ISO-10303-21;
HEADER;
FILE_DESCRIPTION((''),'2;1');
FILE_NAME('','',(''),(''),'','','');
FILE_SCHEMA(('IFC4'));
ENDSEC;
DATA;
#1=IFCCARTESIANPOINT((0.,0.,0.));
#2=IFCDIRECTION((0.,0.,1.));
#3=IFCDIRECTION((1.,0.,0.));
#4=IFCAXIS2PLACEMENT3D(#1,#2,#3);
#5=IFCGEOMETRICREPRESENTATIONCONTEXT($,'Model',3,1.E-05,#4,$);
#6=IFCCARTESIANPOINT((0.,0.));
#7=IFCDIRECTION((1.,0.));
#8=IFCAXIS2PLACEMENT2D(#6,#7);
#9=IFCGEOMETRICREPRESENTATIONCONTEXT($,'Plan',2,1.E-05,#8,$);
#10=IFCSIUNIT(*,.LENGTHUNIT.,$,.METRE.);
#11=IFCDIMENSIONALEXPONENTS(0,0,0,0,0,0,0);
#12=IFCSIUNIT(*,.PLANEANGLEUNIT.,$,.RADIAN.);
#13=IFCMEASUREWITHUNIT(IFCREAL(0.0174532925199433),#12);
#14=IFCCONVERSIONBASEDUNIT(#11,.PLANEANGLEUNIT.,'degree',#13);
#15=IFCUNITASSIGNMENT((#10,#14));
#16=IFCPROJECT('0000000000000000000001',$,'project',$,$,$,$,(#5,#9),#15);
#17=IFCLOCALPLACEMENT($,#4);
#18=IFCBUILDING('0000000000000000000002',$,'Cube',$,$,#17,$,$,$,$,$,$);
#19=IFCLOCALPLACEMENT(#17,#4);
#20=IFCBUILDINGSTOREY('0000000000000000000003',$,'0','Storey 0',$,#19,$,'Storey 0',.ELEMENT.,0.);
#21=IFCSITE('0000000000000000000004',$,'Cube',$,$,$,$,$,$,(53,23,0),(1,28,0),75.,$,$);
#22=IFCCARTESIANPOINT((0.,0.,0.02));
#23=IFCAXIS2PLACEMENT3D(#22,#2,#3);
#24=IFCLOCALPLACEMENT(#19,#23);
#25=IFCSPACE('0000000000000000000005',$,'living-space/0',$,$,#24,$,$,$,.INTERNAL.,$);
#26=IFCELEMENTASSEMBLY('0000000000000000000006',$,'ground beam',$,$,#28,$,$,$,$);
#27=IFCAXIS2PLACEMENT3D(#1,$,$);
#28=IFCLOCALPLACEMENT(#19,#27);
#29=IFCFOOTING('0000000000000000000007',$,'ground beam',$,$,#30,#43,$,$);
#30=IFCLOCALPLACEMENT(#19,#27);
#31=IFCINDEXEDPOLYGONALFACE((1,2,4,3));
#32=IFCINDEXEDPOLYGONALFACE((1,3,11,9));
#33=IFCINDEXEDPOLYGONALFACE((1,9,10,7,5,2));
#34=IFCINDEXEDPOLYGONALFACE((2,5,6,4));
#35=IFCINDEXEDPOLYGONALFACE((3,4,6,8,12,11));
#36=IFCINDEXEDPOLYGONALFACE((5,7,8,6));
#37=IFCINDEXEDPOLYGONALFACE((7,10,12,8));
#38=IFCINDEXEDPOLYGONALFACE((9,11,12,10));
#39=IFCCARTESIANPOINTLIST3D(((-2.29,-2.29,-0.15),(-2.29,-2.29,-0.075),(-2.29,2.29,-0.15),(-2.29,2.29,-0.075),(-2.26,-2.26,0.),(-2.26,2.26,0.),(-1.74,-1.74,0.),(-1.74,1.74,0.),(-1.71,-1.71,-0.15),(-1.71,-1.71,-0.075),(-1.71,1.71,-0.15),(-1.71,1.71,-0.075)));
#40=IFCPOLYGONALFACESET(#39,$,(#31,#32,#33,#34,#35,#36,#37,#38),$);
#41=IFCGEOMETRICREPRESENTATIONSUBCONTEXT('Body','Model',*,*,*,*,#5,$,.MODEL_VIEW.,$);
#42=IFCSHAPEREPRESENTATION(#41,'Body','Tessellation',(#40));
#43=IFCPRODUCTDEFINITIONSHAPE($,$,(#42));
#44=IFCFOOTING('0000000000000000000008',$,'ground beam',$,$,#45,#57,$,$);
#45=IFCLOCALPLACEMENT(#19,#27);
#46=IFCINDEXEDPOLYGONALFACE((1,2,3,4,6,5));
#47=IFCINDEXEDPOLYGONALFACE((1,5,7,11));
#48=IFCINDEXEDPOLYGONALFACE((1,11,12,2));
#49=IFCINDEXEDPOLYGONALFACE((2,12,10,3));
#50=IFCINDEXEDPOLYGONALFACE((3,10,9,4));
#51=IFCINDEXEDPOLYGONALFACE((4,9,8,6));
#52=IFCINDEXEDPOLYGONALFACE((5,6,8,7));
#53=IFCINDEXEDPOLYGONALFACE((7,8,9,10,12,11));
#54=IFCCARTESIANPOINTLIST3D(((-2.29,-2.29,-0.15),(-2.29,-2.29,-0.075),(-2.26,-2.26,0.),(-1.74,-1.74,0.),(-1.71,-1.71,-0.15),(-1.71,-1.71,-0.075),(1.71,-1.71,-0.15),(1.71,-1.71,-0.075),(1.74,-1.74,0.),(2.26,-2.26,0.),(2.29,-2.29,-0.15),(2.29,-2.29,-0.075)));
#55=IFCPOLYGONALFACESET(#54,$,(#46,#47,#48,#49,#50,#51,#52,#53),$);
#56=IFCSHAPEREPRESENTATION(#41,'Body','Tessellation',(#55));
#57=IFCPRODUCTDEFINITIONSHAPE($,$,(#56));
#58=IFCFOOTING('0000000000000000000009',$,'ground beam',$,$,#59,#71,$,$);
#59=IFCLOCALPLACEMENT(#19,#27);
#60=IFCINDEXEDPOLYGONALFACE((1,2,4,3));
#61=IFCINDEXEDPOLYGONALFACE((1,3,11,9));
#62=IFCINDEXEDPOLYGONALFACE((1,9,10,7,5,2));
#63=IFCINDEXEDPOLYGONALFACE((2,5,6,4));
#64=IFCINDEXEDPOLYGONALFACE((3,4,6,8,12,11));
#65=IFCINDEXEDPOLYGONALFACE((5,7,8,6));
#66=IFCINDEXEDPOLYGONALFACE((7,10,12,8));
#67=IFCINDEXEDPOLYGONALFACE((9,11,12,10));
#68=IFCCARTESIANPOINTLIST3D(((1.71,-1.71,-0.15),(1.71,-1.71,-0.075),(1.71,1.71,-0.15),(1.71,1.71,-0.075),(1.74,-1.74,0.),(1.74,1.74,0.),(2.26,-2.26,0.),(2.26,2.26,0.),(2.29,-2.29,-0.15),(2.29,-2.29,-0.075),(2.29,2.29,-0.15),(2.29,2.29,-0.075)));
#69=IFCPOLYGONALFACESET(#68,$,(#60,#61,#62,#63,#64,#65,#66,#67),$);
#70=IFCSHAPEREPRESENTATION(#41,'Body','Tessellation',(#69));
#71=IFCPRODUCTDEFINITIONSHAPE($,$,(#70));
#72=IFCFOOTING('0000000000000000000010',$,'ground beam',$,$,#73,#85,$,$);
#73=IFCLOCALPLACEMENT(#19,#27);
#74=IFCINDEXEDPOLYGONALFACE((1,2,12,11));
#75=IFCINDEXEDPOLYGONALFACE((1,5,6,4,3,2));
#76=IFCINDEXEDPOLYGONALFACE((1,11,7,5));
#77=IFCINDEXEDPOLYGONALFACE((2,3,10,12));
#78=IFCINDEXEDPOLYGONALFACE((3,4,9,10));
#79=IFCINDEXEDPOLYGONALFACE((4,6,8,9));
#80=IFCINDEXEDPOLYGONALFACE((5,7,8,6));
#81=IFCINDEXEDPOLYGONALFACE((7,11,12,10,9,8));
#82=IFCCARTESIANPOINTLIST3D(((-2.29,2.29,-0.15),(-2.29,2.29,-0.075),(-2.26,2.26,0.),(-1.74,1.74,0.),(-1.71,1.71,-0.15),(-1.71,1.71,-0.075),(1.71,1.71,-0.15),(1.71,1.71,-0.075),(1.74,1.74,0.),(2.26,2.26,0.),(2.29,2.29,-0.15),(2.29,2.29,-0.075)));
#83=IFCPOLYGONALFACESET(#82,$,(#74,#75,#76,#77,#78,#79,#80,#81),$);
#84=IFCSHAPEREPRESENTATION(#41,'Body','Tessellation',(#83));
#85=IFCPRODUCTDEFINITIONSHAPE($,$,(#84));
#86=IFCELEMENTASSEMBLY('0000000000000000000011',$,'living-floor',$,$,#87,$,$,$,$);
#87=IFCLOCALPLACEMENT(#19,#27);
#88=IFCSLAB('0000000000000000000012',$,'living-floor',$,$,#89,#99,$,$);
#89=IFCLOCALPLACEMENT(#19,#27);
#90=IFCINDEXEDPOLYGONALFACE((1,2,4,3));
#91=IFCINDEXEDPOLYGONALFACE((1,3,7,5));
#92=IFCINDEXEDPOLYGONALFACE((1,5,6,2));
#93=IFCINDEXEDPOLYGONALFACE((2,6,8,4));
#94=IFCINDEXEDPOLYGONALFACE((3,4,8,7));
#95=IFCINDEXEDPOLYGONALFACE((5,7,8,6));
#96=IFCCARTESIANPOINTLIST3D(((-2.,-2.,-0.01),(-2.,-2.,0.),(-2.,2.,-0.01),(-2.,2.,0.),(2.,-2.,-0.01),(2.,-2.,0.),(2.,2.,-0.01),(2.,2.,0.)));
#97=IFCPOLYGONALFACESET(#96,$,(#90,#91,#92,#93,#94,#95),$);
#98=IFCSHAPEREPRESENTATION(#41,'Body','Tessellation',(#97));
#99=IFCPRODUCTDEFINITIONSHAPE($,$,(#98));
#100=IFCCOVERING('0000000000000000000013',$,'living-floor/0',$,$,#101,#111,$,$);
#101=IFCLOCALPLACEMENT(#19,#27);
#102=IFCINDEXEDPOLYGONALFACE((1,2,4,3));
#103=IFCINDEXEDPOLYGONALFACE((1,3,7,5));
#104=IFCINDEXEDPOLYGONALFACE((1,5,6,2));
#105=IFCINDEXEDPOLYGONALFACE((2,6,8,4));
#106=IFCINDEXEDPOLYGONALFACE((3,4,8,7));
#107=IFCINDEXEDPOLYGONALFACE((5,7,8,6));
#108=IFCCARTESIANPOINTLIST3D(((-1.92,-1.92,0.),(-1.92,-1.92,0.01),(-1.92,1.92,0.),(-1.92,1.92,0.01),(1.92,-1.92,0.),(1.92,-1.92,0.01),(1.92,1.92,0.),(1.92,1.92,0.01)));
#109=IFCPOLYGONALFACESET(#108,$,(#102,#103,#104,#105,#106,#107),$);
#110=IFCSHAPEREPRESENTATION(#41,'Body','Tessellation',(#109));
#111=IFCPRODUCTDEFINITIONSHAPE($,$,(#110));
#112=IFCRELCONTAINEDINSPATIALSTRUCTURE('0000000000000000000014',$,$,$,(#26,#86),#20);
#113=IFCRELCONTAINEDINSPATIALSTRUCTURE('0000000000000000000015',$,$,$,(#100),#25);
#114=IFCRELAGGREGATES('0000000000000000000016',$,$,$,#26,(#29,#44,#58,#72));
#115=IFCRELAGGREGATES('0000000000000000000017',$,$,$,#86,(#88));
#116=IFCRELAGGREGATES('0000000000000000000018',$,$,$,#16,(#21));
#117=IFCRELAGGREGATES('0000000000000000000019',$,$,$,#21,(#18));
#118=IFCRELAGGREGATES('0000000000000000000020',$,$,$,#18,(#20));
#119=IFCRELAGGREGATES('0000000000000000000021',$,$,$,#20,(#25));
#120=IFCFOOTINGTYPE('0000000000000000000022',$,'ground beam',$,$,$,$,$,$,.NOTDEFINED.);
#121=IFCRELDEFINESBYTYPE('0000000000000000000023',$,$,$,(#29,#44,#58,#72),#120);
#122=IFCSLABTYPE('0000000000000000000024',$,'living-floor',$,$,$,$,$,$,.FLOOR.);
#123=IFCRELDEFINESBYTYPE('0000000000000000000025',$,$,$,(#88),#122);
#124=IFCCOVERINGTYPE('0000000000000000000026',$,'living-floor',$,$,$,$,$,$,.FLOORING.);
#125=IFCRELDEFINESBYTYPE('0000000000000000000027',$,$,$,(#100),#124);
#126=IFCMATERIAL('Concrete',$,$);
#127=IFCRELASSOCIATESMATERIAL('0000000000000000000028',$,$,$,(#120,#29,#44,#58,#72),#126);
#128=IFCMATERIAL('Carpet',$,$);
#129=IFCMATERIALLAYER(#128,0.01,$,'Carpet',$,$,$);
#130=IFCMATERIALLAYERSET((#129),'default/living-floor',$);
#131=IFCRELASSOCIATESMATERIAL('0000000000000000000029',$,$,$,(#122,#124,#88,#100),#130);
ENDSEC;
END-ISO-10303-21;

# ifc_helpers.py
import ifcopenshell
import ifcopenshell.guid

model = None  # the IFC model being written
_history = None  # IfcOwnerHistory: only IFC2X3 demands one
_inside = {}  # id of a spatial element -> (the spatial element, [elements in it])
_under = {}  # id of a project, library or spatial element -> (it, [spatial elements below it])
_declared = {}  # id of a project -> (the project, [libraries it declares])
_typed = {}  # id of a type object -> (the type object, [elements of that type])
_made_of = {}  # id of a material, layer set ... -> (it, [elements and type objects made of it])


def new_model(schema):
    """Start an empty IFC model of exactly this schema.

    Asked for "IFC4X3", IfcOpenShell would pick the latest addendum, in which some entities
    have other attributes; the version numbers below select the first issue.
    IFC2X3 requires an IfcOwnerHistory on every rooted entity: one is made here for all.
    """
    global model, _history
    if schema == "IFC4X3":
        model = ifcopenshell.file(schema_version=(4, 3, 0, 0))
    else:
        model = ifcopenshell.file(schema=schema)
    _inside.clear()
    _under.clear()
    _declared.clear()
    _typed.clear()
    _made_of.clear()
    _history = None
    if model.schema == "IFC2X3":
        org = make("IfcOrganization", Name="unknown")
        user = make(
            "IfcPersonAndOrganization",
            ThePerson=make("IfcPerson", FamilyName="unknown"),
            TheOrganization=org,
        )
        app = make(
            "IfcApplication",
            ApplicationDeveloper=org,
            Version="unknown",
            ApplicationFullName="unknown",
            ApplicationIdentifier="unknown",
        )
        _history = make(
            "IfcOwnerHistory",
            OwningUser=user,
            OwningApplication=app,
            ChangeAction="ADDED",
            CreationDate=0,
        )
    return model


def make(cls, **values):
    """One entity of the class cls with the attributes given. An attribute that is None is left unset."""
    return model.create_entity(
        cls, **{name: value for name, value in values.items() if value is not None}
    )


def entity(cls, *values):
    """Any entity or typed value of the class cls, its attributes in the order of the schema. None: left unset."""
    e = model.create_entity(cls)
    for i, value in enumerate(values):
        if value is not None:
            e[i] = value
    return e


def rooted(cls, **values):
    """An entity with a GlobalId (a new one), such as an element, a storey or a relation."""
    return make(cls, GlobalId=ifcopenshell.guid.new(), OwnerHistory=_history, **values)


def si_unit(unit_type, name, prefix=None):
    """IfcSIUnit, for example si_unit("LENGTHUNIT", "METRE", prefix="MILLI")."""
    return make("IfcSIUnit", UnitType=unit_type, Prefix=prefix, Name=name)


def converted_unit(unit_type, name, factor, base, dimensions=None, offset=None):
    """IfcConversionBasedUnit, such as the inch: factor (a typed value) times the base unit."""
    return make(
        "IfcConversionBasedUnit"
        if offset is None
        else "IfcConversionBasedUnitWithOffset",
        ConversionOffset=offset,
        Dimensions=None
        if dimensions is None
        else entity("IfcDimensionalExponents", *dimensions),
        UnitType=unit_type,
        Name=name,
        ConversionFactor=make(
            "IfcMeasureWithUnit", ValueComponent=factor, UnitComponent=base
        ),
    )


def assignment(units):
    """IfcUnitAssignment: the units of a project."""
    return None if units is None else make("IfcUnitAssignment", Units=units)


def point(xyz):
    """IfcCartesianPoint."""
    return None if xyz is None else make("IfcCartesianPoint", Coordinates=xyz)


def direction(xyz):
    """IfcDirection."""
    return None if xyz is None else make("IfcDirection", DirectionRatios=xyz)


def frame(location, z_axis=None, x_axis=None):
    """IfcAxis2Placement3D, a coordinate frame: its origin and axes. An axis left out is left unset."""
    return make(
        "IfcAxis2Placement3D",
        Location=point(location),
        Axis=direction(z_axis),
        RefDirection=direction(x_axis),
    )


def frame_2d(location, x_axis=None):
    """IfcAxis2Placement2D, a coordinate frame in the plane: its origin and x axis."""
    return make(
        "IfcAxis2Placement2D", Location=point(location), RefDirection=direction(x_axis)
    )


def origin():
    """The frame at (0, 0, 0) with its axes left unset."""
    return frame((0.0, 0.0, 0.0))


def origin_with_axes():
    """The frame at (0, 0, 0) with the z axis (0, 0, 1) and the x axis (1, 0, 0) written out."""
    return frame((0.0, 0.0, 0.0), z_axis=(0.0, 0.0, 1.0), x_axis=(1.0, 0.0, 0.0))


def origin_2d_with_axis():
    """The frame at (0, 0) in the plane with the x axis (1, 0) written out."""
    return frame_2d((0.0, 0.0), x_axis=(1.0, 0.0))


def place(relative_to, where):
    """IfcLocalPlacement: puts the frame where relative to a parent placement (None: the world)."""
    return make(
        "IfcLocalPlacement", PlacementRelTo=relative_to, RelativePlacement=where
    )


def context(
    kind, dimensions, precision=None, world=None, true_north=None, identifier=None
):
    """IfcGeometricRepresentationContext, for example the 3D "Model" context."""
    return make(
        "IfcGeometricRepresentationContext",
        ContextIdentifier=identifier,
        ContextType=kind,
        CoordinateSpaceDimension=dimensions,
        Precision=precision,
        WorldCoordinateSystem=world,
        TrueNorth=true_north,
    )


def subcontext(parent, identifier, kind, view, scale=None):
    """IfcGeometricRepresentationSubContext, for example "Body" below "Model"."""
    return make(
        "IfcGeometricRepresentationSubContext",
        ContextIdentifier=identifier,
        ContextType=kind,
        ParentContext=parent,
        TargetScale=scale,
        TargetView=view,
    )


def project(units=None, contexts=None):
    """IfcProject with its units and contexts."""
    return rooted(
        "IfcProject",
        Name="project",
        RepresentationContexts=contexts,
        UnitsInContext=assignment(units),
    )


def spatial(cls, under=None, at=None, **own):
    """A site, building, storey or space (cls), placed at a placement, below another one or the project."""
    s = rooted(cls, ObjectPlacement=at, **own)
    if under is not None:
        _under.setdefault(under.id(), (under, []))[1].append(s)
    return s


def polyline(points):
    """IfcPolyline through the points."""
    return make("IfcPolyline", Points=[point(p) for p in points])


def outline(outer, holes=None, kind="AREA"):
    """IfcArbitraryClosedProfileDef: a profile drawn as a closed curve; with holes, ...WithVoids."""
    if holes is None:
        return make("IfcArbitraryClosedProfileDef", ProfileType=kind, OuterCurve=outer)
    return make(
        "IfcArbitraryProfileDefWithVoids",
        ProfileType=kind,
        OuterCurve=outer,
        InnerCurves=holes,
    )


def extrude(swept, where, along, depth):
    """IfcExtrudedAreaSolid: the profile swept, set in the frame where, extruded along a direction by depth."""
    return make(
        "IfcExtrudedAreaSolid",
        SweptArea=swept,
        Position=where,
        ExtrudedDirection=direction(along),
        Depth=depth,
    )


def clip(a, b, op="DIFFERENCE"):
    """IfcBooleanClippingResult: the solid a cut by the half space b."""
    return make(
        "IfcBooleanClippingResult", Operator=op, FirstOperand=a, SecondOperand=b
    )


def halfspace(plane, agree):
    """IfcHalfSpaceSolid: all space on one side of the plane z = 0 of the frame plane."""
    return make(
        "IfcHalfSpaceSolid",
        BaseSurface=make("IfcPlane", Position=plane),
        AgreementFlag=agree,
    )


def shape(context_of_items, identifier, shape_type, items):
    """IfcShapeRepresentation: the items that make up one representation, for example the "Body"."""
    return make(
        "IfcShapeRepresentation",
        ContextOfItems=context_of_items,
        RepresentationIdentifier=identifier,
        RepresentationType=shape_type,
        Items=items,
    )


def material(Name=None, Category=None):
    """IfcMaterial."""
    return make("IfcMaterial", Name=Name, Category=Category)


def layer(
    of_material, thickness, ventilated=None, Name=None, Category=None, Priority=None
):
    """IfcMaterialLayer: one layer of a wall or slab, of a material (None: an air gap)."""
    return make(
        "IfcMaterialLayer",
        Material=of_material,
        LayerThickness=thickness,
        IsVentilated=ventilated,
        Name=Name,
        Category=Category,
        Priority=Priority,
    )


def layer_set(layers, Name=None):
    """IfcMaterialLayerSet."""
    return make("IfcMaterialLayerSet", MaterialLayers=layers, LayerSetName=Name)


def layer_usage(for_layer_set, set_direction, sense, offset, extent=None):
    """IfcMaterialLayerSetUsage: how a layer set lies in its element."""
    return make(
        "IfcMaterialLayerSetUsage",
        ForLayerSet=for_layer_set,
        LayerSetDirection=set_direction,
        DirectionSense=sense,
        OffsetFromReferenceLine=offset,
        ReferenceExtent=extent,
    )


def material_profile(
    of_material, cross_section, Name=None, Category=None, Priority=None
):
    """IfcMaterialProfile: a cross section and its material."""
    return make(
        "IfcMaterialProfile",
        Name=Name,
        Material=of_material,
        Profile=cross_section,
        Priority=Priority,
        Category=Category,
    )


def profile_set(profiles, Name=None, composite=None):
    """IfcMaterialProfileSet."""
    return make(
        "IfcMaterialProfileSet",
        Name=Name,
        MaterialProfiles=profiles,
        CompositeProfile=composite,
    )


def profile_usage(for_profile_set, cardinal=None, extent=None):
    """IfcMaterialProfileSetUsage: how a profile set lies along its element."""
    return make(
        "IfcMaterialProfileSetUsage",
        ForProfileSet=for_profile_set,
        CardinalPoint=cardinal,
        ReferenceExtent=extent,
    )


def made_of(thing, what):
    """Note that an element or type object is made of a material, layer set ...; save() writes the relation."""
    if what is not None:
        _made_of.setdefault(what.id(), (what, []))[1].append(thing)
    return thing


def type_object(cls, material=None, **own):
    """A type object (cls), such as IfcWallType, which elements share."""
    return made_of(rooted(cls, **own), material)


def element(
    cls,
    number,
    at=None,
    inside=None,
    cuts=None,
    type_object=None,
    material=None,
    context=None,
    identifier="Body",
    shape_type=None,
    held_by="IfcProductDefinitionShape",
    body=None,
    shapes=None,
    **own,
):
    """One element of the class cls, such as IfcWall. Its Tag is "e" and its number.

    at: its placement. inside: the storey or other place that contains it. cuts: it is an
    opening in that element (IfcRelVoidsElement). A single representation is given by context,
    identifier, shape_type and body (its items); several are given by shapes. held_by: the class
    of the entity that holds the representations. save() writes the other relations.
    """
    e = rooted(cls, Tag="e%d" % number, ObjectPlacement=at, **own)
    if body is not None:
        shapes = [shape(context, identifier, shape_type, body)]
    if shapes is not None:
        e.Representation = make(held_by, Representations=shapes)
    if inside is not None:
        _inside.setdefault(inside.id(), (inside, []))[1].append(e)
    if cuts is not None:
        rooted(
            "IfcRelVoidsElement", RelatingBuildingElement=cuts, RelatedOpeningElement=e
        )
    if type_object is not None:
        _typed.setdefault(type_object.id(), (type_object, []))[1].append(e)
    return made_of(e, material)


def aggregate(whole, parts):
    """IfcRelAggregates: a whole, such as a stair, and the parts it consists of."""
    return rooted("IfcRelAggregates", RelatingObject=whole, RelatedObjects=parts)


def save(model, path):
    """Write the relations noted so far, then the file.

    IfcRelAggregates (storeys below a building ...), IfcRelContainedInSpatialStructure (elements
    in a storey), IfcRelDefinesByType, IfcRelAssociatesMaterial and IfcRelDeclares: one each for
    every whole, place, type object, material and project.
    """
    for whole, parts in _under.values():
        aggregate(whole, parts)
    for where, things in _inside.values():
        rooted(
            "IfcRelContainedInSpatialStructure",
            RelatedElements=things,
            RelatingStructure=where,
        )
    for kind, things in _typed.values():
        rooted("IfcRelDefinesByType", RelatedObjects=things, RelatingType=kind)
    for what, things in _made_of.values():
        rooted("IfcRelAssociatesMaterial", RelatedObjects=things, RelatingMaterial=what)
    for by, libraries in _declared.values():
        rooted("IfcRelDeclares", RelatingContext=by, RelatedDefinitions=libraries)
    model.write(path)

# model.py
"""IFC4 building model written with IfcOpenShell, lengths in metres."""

from ifc_helpers import new_model, entity, si_unit, converted_unit, frame, origin, origin_with_axes, origin_2d_with_axis, place, context, subcontext, project, spatial, polyline, outline, extrude, clip, halfspace, material, layer, layer_set, layer_usage, material_profile, profile_set, profile_usage, type_object, element, aggregate, save


model = new_model("IFC4")

# Units and contexts
model_context = context("Model", 3, precision=1e-05, world=origin_with_axes())
plan_context = context("Plan", 2, precision=1e-05, world=origin_2d_with_axis())
body_context = subcontext(model_context, "Body", "Model", "MODEL_VIEW")
ifc_project = project(units=[si_unit("LENGTHUNIT", "METRE"), converted_unit("PLANEANGLEUNIT", "degree", entity("IfcReal", 0.0174532925199433), si_unit("PLANEANGLEUNIT", "RADIAN"), dimensions=[0, 0, 0, 0, 0, 0, 0])], contexts=[model_context, plan_context])

# Site, building, storey
site = spatial("IfcSite", under=ifc_project, Name="Cube", RefLatitude=(53, 23, 0), RefLongitude=(1, 28, 0), RefElevation=75.0)
building_placement = place(None, origin_with_axes())
building = spatial("IfcBuilding", under=site, at=building_placement, Name="Cube")
storey_placement = place(building_placement, origin_with_axes())
storey = spatial("IfcBuildingStorey", under=building, at=storey_placement, Name="0", Description="Storey 0", LongName="Storey 0", CompositionType="ELEMENT", Elevation=0.0)

# Element assembly, footings
assembly_1_placement = place(storey_placement, origin_with_axes())
assembly_1 = element("IfcElementAssembly", 1, at=assembly_1_placement, inside=storey, Name="ground beam")
ifc_material_1 = material(Name="Concrete")
ifc_material_profile = material_profile(ifc_material_1, outline(polyline([(-0.26, 0.0), (-0.29, -0.075), (-0.29, -0.15), (0.29, -0.15), (0.29, -0.075), (0.26, 0.0), (-0.26, 0.0)])))
ifc_profile_set = profile_set([ifc_material_profile])
ifc_profile_usage_1 = profile_usage(ifc_profile_set)
footing_type = type_object("IfcFootingType", Name="ground beam", PredefinedType="NOTDEFINED", material=ifc_profile_set)
footing_1_placement = place(assembly_1_placement, frame((-2.0, -3.0, 0.0), z_axis=(0.0, 1.0, 0.0), x_axis=(-1.0, 0.0, 0.0)))
footing_1 = element("IfcFooting", 2, at=footing_1_placement, type_object=footing_type, material=ifc_profile_usage_1, Name="ground beam", context=body_context, shape_type="Clipping", body=[
    clip(clip(extrude(outline(polyline([(-0.26, 0.0), (-0.29, -0.075), (-0.29, -0.15), (0.29, -0.15), (0.29, -0.075), (0.26, 0.0), (-0.26, 0.0)])), origin_with_axes(), (0.0, 0.0, 1.0), 6.0), halfspace(frame((0.0, 0.0, 1.0), z_axis=(-0.707107, 0.0, -0.707107), x_axis=(0.0, 1.0, 0.0)), False)), halfspace(frame((0.0, 0.0, 5.0), z_axis=(-0.707107, 0.0, 0.707107), x_axis=(0.0, 1.0, 0.0)), False)),
])
ifc_profile_usage_2 = profile_usage(ifc_profile_set)
footing_2_placement = place(assembly_1_placement, frame((3.0, -2.0, 0.0), z_axis=(-1.0, 0.0, 0.0), x_axis=(0.0, -1.0, 0.0)))
footing_2 = element("IfcFooting", 3, at=footing_2_placement, type_object=footing_type, material=ifc_profile_usage_2, Name="ground beam", context=body_context, shape_type="Clipping", body=[
    clip(clip(extrude(outline(polyline([(-0.26, 0.0), (-0.29, -0.075), (-0.29, -0.15), (0.29, -0.15), (0.29, -0.075), (0.26, 0.0), (-0.26, 0.0)])), origin_with_axes(), (0.0, 0.0, 1.0), 6.0), halfspace(frame((0.0, 0.0, 1.0), z_axis=(-0.707107, 0.0, -0.707107), x_axis=(0.0, 1.0, 0.0)), False)), halfspace(frame((0.0, 0.0, 5.0), z_axis=(-0.707107, 0.0, 0.707107), x_axis=(0.0, 1.0, 0.0)), False)),
])
ifc_profile_usage_3 = profile_usage(ifc_profile_set)
footing_3_placement = place(assembly_1_placement, frame((2.0, 3.0, 0.0), z_axis=(0.0, -1.0, 0.0), x_axis=(1.0, 0.0, 0.0)))
footing_3 = element("IfcFooting", 4, at=footing_3_placement, type_object=footing_type, material=ifc_profile_usage_3, Name="ground beam", context=body_context, shape_type="Clipping", body=[
    clip(clip(extrude(outline(polyline([(-0.26, 0.0), (-0.29, -0.075), (-0.29, -0.15), (0.29, -0.15), (0.29, -0.075), (0.26, 0.0), (-0.26, 0.0)])), origin_with_axes(), (0.0, 0.0, 1.0), 6.0), halfspace(frame((0.0, 0.0, 1.0), z_axis=(-0.707107, 0.0, -0.707107), x_axis=(0.0, 1.0, 0.0)), False)), halfspace(frame((0.0, 0.0, 5.0), z_axis=(-0.707107, 0.0, 0.707107), x_axis=(0.0, 1.0, 0.0)), False)),
])
ifc_profile_usage_4 = profile_usage(ifc_profile_set)
footing_4_placement = place(assembly_1_placement, frame((-3.0, 2.0, 0.0), z_axis=(1.0, 0.0, 0.0), x_axis=(0.0, 1.0, 0.0)))
footing_4 = element("IfcFooting", 5, at=footing_4_placement, type_object=footing_type, material=ifc_profile_usage_4, Name="ground beam", context=body_context, shape_type="Clipping", body=[
    clip(clip(extrude(outline(polyline([(-0.26, 0.0), (-0.29, -0.075), (-0.29, -0.15), (0.29, -0.15), (0.29, -0.075), (0.26, 0.0), (-0.26, 0.0)])), origin_with_axes(), (0.0, 0.0, 1.0), 6.0), halfspace(frame((0.0, 0.0, 1.0), z_axis=(-0.707107, 0.0, -0.707107), x_axis=(0.0, 1.0, 0.0)), False)), halfspace(frame((0.0, 0.0, 5.0), z_axis=(-0.707107, 0.0, 0.707107), x_axis=(0.0, 1.0, 0.0)), False)),
])
aggregate(assembly_1, [footing_1, footing_2, footing_3, footing_4])

# Element assembly, slab
assembly_2_placement = place(storey_placement, origin_with_axes())
assembly_2 = element("IfcElementAssembly", 6, at=assembly_2_placement, inside=storey, Name="living-floor")
ifc_material_2 = material(Name="Carpet")
ifc_layer_1 = layer(ifc_material_2, 0.01, Name="Carpet")
ifc_layer_set_1 = layer_set([ifc_layer_1], Name="default/living-floor")
ifc_layer_usage_1 = layer_usage(ifc_layer_set_1, "AXIS3", "POSITIVE", 0.0)
slab_type = type_object("IfcSlabType", Name="living-floor", PredefinedType="FLOOR", material=ifc_layer_set_1)
slab_placement = place(assembly_2_placement, frame((2.0, 2.0, -0.01), z_axis=(0.0, 0.0, -1.0), x_axis=(0.0, 1.0, 0.0)))
slab = element("IfcSlab", 7, at=slab_placement, type_object=slab_type, material=ifc_layer_usage_1, Name="living-floor", context=body_context, shape_type="SweptSolid", body=[
    extrude(outline(polyline([(0.0, 0.0), (-4.0, 0.0), (-4.0, -4.0), (0.0, -4.0), (0.0, 0.0)])), origin(), (0.0, 0.0, -1.0), 0.01),
])
aggregate(assembly_2, [slab])

# Shared definitions
space_placement = place(storey_placement, frame((0.0, 0.0, 0.02), z_axis=(0.0, 0.0, 1.0), x_axis=(1.0, 0.0, 0.0)))
space = spatial("IfcSpace", under=storey, at=space_placement, Name="living-space/0", PredefinedType="INTERNAL")

# Covering
ifc_layer_usage_2 = layer_usage(ifc_layer_set_1, "AXIS3", "POSITIVE", 0.0)
covering_type = type_object("IfcCoveringType", Name="living-floor", PredefinedType="FLOORING", material=ifc_layer_set_1)
covering_placement = place(space_placement, frame((0.0, 0.0, -0.02), z_axis=(0.0, 0.0, 1.0), x_axis=(1.0, 0.0, 0.0)))
element("IfcCovering", 8, at=covering_placement, inside=space, type_object=covering_type, material=ifc_layer_usage_2, Name="living-floor/0", context=body_context, shape_type="SweptSolid", body=[
    extrude(outline(polyline([(1.92, 1.92), (-1.92, 1.92), (-1.92, -1.92), (1.92, -1.92), (1.92, 1.92)])), origin_with_axes(), (0.0, 0.0, 1.0), 0.01),
])

save(model, "model.ifc")
